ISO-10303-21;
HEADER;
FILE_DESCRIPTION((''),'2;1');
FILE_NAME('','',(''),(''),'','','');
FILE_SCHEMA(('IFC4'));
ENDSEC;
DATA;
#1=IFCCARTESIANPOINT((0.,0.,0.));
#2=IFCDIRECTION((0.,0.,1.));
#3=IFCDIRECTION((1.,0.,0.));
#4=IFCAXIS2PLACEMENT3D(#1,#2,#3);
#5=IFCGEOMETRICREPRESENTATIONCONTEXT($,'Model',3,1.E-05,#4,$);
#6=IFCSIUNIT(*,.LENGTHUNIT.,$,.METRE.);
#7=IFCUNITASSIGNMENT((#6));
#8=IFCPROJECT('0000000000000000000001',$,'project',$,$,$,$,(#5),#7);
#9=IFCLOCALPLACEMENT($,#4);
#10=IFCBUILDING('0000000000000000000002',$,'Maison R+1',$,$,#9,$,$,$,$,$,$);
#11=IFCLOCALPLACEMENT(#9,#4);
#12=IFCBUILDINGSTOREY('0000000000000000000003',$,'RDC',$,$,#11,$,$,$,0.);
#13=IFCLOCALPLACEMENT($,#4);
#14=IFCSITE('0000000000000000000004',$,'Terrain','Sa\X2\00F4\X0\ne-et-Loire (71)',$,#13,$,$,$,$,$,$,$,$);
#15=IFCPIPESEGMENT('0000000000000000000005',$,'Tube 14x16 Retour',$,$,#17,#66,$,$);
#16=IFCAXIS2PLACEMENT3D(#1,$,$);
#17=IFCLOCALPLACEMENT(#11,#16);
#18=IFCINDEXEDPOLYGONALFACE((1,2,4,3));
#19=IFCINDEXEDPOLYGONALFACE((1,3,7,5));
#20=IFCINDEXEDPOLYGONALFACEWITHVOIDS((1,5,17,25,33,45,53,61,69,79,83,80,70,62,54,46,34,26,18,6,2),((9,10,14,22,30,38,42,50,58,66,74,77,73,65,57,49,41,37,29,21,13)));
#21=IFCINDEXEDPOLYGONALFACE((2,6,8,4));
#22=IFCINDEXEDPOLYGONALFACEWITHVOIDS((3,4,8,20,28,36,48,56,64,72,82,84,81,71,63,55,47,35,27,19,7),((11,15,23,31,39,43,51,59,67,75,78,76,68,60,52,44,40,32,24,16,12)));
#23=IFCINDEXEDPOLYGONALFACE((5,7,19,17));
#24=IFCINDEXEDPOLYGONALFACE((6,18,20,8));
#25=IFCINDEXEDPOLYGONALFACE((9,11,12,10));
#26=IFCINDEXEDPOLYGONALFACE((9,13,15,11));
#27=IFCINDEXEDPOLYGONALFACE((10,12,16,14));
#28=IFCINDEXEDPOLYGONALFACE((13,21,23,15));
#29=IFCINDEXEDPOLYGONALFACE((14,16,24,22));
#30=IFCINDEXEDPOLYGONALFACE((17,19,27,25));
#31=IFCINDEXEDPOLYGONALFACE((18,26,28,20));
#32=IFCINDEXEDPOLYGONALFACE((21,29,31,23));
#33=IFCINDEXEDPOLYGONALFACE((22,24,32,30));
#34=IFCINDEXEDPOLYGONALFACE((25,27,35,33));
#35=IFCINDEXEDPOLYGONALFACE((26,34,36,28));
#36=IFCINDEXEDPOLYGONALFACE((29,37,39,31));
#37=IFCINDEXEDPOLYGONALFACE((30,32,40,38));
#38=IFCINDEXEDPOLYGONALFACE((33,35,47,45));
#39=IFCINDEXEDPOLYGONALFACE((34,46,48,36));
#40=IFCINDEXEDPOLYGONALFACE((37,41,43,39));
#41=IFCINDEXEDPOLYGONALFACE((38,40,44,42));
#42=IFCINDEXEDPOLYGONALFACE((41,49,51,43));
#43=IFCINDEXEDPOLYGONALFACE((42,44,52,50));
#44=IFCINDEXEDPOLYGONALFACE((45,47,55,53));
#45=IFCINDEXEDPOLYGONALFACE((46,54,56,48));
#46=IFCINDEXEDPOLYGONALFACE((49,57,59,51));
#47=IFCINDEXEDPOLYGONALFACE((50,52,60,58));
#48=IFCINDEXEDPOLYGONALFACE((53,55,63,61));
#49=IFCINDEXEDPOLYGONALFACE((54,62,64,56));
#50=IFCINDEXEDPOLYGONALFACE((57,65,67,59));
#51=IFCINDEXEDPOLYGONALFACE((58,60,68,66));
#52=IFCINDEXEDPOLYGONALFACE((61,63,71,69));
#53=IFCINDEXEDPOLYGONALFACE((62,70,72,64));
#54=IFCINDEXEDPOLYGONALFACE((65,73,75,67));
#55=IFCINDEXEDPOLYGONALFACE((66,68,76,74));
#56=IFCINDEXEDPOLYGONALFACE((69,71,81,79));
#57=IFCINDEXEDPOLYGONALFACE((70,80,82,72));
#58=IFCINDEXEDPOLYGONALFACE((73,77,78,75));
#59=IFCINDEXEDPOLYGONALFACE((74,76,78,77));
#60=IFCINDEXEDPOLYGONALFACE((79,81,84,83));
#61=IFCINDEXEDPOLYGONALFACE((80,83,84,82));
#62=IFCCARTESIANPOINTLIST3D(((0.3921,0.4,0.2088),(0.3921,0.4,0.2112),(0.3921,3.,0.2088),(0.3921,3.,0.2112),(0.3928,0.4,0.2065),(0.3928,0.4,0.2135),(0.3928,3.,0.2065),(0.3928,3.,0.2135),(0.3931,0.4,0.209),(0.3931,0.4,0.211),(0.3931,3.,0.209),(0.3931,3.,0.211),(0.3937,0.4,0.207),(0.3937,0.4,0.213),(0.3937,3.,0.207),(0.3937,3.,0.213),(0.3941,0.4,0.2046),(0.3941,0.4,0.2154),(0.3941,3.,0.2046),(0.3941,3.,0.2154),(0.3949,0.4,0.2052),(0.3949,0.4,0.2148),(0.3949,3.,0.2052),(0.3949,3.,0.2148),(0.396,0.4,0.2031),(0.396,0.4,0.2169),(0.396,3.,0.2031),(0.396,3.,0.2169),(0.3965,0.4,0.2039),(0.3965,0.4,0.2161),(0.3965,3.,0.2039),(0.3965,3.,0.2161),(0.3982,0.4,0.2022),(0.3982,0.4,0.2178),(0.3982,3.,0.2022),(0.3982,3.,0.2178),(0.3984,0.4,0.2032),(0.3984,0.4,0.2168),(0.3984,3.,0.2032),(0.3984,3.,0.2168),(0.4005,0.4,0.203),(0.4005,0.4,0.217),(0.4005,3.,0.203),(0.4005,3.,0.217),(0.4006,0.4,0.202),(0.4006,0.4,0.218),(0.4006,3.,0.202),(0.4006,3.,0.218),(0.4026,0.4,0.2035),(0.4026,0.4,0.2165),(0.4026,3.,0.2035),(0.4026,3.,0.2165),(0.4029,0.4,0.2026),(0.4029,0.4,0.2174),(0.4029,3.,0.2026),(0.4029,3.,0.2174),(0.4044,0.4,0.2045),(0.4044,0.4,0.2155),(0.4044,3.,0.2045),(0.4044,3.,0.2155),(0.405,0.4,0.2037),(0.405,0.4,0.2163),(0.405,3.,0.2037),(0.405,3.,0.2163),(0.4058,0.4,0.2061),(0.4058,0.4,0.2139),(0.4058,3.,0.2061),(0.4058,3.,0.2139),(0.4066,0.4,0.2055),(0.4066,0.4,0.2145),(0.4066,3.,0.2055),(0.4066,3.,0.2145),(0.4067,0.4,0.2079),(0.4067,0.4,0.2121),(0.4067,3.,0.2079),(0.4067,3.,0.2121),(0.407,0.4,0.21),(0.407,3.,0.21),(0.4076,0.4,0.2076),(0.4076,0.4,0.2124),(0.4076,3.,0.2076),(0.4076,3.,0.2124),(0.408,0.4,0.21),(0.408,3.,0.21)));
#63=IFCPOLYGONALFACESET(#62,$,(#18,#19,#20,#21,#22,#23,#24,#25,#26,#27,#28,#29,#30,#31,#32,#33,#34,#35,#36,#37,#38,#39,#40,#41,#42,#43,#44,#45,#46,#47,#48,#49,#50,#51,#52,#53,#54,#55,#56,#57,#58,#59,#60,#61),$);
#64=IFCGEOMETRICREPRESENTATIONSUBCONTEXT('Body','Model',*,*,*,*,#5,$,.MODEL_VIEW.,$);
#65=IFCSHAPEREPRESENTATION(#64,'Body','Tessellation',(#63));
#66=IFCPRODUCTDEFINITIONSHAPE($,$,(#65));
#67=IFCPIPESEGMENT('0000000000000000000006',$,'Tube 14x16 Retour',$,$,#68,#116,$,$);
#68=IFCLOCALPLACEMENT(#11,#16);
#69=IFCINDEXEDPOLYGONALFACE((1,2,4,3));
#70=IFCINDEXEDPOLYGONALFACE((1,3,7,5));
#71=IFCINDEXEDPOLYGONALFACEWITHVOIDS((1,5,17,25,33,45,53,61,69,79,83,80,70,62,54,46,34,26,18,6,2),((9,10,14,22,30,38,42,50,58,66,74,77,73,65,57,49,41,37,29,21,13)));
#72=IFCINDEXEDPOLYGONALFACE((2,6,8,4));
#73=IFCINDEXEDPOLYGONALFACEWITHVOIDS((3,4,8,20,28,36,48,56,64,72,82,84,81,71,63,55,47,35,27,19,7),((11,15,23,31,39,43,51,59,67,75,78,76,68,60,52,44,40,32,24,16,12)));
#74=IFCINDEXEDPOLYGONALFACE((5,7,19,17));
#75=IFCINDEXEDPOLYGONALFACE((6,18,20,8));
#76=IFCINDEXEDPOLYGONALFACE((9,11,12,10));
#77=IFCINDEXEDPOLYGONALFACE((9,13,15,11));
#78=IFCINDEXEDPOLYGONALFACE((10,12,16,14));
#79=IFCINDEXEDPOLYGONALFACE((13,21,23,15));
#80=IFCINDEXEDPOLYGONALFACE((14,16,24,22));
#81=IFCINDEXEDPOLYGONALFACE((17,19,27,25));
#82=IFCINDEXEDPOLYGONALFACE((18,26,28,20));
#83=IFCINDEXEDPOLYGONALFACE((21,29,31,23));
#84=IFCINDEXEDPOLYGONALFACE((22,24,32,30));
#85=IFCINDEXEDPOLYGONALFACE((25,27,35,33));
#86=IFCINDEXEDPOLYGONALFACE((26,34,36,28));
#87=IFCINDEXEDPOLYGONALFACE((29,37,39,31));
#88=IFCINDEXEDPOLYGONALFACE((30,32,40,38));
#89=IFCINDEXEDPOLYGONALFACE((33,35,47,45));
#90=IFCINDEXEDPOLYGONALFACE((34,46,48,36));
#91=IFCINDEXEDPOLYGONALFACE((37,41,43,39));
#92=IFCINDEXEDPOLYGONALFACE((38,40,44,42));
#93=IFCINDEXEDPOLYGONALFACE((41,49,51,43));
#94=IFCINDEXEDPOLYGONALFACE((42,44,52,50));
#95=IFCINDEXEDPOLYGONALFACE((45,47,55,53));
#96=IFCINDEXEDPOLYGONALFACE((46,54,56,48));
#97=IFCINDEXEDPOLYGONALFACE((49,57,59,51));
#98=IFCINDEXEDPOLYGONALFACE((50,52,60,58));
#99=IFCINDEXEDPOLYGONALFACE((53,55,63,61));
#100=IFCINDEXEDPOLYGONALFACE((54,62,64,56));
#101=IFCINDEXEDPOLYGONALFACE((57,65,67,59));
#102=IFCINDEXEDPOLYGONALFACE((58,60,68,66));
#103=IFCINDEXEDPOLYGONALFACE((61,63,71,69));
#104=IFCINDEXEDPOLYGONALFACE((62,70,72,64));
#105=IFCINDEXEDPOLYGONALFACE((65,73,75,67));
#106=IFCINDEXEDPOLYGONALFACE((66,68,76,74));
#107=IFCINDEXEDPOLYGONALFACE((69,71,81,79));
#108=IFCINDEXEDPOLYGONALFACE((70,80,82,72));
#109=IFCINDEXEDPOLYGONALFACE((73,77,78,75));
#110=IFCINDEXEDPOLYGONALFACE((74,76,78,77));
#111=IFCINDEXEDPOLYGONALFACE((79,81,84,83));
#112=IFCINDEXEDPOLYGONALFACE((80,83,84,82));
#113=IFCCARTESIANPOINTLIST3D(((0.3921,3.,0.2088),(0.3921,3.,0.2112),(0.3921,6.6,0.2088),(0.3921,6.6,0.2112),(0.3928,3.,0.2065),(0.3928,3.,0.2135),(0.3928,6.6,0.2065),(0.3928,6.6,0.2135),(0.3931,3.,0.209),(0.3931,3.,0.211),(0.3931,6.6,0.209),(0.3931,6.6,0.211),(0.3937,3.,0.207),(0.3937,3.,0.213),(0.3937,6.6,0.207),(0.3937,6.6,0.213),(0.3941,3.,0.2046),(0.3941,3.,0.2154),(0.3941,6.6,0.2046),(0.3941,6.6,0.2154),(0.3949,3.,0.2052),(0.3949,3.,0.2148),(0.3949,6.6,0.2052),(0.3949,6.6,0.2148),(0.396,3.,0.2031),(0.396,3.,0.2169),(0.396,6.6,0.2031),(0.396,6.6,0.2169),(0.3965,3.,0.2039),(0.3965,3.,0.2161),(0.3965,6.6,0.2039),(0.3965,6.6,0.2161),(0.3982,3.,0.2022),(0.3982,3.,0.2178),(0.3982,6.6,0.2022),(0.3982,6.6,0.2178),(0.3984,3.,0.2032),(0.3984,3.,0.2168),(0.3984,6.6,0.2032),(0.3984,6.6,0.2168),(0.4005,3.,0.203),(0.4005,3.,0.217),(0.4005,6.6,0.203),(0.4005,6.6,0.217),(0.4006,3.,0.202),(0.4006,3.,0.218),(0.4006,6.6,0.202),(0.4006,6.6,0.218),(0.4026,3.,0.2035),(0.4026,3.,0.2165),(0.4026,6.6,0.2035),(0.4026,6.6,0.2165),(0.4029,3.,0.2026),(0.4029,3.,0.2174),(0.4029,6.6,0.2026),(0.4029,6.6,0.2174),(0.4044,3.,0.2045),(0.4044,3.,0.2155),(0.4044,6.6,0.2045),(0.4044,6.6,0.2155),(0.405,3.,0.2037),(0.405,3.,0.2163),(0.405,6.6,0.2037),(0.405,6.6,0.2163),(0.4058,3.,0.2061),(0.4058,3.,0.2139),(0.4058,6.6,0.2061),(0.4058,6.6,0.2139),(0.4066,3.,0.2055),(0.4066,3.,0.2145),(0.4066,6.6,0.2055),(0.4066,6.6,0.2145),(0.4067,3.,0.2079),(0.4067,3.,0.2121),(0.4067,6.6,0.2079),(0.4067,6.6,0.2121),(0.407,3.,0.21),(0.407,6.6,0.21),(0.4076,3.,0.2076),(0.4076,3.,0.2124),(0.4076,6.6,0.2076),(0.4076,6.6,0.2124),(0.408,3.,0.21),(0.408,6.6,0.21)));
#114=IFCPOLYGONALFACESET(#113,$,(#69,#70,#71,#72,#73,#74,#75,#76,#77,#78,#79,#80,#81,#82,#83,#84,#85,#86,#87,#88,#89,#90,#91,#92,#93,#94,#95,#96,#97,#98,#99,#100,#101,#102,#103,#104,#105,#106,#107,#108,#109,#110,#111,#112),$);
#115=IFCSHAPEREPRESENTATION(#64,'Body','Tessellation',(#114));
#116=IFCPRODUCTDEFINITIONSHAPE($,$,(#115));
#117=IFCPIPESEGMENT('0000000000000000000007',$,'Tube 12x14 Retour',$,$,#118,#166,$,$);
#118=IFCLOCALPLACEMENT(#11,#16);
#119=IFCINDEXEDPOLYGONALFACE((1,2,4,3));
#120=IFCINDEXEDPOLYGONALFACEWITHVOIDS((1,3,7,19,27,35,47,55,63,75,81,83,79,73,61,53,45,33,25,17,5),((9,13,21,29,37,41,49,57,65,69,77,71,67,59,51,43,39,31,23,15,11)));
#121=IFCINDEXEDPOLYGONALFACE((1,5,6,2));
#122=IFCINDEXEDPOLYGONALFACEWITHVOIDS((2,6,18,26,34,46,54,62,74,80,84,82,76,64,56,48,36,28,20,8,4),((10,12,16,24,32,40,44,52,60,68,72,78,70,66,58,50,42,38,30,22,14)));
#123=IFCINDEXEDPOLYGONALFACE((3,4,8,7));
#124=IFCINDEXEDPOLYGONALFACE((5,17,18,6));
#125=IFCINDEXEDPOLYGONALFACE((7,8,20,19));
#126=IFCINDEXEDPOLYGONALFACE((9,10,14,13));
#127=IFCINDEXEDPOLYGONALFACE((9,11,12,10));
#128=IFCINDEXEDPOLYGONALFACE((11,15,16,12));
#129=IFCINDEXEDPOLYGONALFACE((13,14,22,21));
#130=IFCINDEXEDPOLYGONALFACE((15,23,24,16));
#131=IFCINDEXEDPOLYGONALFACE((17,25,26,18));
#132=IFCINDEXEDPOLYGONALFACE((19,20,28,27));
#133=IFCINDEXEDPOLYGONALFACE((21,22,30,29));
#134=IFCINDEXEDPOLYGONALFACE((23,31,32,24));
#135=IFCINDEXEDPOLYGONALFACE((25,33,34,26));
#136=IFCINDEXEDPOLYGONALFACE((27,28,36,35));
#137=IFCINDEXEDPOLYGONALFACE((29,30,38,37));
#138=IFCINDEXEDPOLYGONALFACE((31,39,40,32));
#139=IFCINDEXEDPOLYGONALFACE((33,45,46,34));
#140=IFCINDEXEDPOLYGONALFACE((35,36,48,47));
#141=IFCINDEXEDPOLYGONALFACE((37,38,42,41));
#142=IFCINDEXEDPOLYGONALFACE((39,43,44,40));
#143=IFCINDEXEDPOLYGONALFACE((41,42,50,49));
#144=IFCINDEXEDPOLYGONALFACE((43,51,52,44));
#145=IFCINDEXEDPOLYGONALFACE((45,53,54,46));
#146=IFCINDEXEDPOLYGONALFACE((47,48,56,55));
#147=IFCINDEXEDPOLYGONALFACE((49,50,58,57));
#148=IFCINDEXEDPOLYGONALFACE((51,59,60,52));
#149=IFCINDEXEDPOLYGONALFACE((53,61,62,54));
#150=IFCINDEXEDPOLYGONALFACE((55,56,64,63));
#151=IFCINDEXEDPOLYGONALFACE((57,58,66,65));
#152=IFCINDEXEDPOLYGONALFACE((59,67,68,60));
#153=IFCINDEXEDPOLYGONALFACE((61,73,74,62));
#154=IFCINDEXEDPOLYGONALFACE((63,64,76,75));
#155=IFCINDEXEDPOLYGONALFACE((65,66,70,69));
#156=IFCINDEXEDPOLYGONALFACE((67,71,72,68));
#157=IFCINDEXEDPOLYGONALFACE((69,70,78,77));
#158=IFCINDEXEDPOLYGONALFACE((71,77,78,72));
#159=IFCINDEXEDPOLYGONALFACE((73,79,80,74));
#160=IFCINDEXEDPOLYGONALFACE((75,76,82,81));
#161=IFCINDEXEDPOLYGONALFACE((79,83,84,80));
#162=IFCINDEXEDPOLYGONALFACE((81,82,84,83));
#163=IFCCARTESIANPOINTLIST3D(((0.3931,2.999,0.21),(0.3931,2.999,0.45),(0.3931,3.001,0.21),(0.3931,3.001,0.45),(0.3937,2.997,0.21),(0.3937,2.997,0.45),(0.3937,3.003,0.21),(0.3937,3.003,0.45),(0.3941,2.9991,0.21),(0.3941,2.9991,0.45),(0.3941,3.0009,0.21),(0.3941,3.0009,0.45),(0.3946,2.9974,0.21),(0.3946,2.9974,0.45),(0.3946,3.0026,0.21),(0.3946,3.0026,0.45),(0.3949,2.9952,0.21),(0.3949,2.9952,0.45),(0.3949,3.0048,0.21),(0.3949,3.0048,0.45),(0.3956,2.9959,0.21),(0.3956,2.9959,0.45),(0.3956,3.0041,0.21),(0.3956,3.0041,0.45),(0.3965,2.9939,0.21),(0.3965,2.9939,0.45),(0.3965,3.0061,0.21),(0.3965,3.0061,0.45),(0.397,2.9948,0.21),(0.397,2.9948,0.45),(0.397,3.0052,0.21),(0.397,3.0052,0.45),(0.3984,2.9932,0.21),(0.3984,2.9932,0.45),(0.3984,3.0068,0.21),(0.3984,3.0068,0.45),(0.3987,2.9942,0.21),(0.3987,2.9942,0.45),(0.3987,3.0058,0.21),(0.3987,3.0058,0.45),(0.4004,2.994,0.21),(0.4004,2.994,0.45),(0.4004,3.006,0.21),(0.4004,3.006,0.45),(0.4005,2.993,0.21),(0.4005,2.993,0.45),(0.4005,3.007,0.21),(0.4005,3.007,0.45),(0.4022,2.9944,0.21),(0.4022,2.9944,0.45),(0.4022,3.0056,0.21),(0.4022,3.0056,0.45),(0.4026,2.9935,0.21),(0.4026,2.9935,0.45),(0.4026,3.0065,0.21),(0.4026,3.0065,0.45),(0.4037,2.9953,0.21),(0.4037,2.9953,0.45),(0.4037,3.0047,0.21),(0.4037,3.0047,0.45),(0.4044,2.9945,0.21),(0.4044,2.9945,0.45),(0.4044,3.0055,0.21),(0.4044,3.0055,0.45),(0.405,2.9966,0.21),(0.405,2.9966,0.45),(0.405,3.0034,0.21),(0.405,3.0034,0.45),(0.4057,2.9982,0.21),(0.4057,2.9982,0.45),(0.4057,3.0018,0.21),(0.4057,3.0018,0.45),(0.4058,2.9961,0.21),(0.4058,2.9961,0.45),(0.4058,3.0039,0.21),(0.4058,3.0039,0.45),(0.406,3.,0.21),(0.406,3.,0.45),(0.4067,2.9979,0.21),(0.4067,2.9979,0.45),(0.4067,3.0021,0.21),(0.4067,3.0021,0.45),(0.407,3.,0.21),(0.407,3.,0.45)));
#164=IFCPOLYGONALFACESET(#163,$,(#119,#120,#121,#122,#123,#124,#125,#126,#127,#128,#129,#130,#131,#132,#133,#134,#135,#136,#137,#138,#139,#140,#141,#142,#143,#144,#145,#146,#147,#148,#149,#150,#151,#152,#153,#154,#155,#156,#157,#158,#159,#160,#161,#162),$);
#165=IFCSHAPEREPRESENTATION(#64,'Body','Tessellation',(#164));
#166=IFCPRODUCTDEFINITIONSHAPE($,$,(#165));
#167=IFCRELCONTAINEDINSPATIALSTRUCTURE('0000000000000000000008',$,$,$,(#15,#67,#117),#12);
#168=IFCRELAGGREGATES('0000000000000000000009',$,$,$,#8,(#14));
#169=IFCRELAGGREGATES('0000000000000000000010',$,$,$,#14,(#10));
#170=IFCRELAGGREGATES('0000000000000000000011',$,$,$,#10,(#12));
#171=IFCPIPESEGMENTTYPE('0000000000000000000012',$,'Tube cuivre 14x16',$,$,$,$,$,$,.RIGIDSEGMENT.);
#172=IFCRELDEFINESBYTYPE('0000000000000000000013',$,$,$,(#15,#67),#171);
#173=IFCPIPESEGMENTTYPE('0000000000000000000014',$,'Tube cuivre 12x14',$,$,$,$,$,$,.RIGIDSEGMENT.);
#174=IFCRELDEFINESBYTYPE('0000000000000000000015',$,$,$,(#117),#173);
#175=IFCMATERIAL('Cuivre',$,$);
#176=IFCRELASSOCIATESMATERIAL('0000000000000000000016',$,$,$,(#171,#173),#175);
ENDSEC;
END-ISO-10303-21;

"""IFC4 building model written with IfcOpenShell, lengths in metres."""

from ifc_helpers import new_model, si_unit, frame, origin_with_axes, place, context, subcontext, project, spatial, hollow_circle, extrude, material, type_object, element, save


model = new_model("IFC4")

# Units and contexts
model_context = context("Model", 3, precision=1e-05, world=origin_with_axes())
body_context = subcontext(model_context, "Body", "Model", "MODEL_VIEW")
ifc_project = project(units=[si_unit("LENGTHUNIT", "METRE")], contexts=[model_context])

# Site, building, storey
site_placement = place(None, origin_with_axes())
site = spatial("IfcSite", under=ifc_project, at=site_placement, Name="Terrain", Description="Saône-et-Loire (71)")
building_placement = place(None, origin_with_axes())
building = spatial("IfcBuilding", under=site, at=building_placement, Name="Maison R+1")
storey_placement = place(building_placement, origin_with_axes())
storey = spatial("IfcBuildingStorey", under=building, at=storey_placement, Name="RDC", Elevation=0.0)

# Pipe segments
ifc_material_1 = material(Name="Cuivre")
pipe_segment_type_1 = type_object("IfcPipeSegmentType", Name="Tube cuivre 14x16", PredefinedType="RIGIDSEGMENT", material=ifc_material_1)
pipe_segment_1_placement = place(storey_placement, frame((0.4, 0.4, 0.21), z_axis=(0.0, 1.0, 0.0), x_axis=(1.0, 0.0, 0.0)))
element("IfcPipeSegment", 1, at=pipe_segment_1_placement, inside=storey, type_object=pipe_segment_type_1, Name="Tube 14x16 Retour", context=body_context, shape_type="SweptSolid", body=[
    extrude(hollow_circle(Radius=0.008, WallThickness=0.001), origin_with_axes(), (0.0, 0.0, 1.0), 2.6),
])
pipe_segment_2_placement = place(storey_placement, frame((0.4, 3.0, 0.21), z_axis=(0.0, 1.0, 0.0), x_axis=(1.0, 0.0, 0.0)))
element("IfcPipeSegment", 2, at=pipe_segment_2_placement, inside=storey, type_object=pipe_segment_type_1, Name="Tube 14x16 Retour", context=body_context, shape_type="SweptSolid", body=[
    extrude(hollow_circle(Radius=0.008, WallThickness=0.001), origin_with_axes(), (0.0, 0.0, 1.0), 3.6),
])
pipe_segment_type_2 = type_object("IfcPipeSegmentType", Name="Tube cuivre 12x14", PredefinedType="RIGIDSEGMENT", material=ifc_material_1)
pipe_segment_3_placement = place(storey_placement, frame((0.4, 3.0, 0.21), z_axis=(0.0, 0.0, 1.0), x_axis=(1.0, 0.0, 0.0)))
element("IfcPipeSegment", 3, at=pipe_segment_3_placement, inside=storey, type_object=pipe_segment_type_2, Name="Tube 12x14 Retour", context=body_context, shape_type="SweptSolid", body=[
    extrude(hollow_circle(Radius=0.007, WallThickness=0.001), origin_with_axes(), (0.0, 0.0, 1.0), 0.24),
])

save(model, "model.ifc")
